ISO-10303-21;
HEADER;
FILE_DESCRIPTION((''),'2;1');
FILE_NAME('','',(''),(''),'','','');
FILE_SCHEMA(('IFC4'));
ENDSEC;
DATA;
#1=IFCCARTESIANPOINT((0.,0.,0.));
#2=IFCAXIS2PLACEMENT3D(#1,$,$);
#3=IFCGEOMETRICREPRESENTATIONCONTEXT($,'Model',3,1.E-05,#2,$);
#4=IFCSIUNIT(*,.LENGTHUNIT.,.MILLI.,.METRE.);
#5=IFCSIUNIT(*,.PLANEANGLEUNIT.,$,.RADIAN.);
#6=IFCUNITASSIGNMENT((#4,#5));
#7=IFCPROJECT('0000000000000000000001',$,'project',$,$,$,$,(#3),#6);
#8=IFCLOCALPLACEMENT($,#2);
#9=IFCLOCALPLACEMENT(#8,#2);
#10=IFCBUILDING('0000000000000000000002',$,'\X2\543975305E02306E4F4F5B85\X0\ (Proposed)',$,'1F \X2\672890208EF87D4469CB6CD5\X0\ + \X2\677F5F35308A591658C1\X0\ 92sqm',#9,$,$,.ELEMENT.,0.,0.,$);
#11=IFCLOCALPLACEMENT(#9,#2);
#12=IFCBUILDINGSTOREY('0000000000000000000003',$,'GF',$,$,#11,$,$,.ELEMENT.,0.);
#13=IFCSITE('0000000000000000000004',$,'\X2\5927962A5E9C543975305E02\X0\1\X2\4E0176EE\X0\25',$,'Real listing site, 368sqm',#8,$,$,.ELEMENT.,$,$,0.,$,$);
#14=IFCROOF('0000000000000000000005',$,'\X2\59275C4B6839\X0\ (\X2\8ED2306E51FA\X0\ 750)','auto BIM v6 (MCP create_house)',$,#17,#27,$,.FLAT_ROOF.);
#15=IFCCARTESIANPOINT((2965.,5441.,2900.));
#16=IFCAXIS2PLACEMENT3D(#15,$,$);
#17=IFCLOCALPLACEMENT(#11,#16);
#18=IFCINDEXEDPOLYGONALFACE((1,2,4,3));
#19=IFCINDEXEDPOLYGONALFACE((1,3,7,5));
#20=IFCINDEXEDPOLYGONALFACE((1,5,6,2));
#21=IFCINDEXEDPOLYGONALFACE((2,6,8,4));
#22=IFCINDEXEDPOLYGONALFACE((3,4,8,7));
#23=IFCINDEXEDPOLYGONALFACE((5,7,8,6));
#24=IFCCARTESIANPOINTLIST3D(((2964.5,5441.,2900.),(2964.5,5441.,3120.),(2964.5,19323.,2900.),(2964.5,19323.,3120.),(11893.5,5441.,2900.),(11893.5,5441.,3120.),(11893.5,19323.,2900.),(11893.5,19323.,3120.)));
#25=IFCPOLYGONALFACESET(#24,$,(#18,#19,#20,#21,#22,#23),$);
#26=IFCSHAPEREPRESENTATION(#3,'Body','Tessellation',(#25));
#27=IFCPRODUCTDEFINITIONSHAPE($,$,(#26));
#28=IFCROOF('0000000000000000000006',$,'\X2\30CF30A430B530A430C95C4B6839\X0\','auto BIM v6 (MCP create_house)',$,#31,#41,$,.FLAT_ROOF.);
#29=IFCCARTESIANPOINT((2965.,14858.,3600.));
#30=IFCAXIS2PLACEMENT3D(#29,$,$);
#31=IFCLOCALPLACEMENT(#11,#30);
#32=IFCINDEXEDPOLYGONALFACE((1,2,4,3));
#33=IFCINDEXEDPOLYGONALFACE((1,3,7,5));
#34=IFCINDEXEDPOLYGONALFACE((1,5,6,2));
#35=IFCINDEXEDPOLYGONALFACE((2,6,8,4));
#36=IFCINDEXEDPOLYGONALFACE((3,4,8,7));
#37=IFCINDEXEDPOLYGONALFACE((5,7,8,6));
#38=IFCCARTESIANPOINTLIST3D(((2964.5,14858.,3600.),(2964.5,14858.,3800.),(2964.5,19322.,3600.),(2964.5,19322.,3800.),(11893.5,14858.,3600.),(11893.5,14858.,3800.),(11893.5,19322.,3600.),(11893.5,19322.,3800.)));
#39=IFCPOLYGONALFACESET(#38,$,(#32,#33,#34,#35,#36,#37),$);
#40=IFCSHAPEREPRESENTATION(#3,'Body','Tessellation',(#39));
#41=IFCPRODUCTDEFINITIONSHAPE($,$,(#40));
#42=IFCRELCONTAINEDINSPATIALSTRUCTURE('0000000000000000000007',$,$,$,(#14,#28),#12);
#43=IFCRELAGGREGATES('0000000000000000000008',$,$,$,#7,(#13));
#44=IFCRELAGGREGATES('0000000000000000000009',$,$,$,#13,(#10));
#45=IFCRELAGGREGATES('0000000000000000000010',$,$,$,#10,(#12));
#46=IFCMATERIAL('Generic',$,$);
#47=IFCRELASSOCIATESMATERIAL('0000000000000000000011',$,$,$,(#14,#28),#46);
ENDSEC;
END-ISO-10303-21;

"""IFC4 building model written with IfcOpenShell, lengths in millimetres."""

from ifc_helpers import new_model, si_unit, frame, frame_2d, origin, place, context, project, spatial, rectangle, extrude, material, element, save


model = new_model("IFC4")

# Units and contexts
model_context = context("Model", 3, precision=1e-05, world=origin())
ifc_project = project(units=[si_unit("LENGTHUNIT", "METRE", prefix="MILLI"), si_unit("PLANEANGLEUNIT", "RADIAN")], contexts=[model_context])

# Site, building, storey
site_placement = place(None, origin())
site = spatial("IfcSite", under=ifc_project, at=site_placement, Name="大阪府吹田市1丁目25", ObjectType="Real listing site, 368sqm", CompositionType="ELEMENT", RefElevation=0.0)
building_placement = place(site_placement, origin())
building = spatial("IfcBuilding", under=site, at=building_placement, Name="吹田市の住宅 (Proposed)", ObjectType="1F 木造軸組構法 + 板張り外壁 92sqm", CompositionType="ELEMENT", ElevationOfRefHeight=0.0, ElevationOfTerrain=0.0)
storey_placement = place(building_placement, origin())
storey = spatial("IfcBuildingStorey", under=building, at=storey_placement, Name="GF", CompositionType="ELEMENT", Elevation=0.0)

# Shared definitions
ifc_material = material(Name="Generic")

# Roofs
roof_1_placement = place(storey_placement, frame((2965.0, 5441.0, 2900.0)))
element("IfcRoof", 1, at=roof_1_placement, inside=storey, material=ifc_material, Name="大屋根 (軒の出 750)", Description="auto BIM v6 (MCP create_house)", PredefinedType="FLAT_ROOF", context=model_context, shape_type="SweptSolid", body=[
    extrude(rectangle(XDim=8929.0, YDim=13882.0, at=frame_2d((4464.0, 6941.0))), frame((2965.0, 5441.0, 2900.0)), (0.0, 0.0, 1.0), 220.0),
])
roof_2_placement = place(storey_placement, frame((2965.0, 14858.0, 3600.0)))
element("IfcRoof", 2, at=roof_2_placement, inside=storey, material=ifc_material, Name="ハイサイド屋根", Description="auto BIM v6 (MCP create_house)", PredefinedType="FLAT_ROOF", context=model_context, shape_type="SweptSolid", body=[
    extrude(rectangle(XDim=8929.0, YDim=4464.0, at=frame_2d((4464.0, 2232.0))), frame((2965.0, 14858.0, 3600.0)), (0.0, 0.0, 1.0), 200.0),
])

save(model, "model.ifc")
